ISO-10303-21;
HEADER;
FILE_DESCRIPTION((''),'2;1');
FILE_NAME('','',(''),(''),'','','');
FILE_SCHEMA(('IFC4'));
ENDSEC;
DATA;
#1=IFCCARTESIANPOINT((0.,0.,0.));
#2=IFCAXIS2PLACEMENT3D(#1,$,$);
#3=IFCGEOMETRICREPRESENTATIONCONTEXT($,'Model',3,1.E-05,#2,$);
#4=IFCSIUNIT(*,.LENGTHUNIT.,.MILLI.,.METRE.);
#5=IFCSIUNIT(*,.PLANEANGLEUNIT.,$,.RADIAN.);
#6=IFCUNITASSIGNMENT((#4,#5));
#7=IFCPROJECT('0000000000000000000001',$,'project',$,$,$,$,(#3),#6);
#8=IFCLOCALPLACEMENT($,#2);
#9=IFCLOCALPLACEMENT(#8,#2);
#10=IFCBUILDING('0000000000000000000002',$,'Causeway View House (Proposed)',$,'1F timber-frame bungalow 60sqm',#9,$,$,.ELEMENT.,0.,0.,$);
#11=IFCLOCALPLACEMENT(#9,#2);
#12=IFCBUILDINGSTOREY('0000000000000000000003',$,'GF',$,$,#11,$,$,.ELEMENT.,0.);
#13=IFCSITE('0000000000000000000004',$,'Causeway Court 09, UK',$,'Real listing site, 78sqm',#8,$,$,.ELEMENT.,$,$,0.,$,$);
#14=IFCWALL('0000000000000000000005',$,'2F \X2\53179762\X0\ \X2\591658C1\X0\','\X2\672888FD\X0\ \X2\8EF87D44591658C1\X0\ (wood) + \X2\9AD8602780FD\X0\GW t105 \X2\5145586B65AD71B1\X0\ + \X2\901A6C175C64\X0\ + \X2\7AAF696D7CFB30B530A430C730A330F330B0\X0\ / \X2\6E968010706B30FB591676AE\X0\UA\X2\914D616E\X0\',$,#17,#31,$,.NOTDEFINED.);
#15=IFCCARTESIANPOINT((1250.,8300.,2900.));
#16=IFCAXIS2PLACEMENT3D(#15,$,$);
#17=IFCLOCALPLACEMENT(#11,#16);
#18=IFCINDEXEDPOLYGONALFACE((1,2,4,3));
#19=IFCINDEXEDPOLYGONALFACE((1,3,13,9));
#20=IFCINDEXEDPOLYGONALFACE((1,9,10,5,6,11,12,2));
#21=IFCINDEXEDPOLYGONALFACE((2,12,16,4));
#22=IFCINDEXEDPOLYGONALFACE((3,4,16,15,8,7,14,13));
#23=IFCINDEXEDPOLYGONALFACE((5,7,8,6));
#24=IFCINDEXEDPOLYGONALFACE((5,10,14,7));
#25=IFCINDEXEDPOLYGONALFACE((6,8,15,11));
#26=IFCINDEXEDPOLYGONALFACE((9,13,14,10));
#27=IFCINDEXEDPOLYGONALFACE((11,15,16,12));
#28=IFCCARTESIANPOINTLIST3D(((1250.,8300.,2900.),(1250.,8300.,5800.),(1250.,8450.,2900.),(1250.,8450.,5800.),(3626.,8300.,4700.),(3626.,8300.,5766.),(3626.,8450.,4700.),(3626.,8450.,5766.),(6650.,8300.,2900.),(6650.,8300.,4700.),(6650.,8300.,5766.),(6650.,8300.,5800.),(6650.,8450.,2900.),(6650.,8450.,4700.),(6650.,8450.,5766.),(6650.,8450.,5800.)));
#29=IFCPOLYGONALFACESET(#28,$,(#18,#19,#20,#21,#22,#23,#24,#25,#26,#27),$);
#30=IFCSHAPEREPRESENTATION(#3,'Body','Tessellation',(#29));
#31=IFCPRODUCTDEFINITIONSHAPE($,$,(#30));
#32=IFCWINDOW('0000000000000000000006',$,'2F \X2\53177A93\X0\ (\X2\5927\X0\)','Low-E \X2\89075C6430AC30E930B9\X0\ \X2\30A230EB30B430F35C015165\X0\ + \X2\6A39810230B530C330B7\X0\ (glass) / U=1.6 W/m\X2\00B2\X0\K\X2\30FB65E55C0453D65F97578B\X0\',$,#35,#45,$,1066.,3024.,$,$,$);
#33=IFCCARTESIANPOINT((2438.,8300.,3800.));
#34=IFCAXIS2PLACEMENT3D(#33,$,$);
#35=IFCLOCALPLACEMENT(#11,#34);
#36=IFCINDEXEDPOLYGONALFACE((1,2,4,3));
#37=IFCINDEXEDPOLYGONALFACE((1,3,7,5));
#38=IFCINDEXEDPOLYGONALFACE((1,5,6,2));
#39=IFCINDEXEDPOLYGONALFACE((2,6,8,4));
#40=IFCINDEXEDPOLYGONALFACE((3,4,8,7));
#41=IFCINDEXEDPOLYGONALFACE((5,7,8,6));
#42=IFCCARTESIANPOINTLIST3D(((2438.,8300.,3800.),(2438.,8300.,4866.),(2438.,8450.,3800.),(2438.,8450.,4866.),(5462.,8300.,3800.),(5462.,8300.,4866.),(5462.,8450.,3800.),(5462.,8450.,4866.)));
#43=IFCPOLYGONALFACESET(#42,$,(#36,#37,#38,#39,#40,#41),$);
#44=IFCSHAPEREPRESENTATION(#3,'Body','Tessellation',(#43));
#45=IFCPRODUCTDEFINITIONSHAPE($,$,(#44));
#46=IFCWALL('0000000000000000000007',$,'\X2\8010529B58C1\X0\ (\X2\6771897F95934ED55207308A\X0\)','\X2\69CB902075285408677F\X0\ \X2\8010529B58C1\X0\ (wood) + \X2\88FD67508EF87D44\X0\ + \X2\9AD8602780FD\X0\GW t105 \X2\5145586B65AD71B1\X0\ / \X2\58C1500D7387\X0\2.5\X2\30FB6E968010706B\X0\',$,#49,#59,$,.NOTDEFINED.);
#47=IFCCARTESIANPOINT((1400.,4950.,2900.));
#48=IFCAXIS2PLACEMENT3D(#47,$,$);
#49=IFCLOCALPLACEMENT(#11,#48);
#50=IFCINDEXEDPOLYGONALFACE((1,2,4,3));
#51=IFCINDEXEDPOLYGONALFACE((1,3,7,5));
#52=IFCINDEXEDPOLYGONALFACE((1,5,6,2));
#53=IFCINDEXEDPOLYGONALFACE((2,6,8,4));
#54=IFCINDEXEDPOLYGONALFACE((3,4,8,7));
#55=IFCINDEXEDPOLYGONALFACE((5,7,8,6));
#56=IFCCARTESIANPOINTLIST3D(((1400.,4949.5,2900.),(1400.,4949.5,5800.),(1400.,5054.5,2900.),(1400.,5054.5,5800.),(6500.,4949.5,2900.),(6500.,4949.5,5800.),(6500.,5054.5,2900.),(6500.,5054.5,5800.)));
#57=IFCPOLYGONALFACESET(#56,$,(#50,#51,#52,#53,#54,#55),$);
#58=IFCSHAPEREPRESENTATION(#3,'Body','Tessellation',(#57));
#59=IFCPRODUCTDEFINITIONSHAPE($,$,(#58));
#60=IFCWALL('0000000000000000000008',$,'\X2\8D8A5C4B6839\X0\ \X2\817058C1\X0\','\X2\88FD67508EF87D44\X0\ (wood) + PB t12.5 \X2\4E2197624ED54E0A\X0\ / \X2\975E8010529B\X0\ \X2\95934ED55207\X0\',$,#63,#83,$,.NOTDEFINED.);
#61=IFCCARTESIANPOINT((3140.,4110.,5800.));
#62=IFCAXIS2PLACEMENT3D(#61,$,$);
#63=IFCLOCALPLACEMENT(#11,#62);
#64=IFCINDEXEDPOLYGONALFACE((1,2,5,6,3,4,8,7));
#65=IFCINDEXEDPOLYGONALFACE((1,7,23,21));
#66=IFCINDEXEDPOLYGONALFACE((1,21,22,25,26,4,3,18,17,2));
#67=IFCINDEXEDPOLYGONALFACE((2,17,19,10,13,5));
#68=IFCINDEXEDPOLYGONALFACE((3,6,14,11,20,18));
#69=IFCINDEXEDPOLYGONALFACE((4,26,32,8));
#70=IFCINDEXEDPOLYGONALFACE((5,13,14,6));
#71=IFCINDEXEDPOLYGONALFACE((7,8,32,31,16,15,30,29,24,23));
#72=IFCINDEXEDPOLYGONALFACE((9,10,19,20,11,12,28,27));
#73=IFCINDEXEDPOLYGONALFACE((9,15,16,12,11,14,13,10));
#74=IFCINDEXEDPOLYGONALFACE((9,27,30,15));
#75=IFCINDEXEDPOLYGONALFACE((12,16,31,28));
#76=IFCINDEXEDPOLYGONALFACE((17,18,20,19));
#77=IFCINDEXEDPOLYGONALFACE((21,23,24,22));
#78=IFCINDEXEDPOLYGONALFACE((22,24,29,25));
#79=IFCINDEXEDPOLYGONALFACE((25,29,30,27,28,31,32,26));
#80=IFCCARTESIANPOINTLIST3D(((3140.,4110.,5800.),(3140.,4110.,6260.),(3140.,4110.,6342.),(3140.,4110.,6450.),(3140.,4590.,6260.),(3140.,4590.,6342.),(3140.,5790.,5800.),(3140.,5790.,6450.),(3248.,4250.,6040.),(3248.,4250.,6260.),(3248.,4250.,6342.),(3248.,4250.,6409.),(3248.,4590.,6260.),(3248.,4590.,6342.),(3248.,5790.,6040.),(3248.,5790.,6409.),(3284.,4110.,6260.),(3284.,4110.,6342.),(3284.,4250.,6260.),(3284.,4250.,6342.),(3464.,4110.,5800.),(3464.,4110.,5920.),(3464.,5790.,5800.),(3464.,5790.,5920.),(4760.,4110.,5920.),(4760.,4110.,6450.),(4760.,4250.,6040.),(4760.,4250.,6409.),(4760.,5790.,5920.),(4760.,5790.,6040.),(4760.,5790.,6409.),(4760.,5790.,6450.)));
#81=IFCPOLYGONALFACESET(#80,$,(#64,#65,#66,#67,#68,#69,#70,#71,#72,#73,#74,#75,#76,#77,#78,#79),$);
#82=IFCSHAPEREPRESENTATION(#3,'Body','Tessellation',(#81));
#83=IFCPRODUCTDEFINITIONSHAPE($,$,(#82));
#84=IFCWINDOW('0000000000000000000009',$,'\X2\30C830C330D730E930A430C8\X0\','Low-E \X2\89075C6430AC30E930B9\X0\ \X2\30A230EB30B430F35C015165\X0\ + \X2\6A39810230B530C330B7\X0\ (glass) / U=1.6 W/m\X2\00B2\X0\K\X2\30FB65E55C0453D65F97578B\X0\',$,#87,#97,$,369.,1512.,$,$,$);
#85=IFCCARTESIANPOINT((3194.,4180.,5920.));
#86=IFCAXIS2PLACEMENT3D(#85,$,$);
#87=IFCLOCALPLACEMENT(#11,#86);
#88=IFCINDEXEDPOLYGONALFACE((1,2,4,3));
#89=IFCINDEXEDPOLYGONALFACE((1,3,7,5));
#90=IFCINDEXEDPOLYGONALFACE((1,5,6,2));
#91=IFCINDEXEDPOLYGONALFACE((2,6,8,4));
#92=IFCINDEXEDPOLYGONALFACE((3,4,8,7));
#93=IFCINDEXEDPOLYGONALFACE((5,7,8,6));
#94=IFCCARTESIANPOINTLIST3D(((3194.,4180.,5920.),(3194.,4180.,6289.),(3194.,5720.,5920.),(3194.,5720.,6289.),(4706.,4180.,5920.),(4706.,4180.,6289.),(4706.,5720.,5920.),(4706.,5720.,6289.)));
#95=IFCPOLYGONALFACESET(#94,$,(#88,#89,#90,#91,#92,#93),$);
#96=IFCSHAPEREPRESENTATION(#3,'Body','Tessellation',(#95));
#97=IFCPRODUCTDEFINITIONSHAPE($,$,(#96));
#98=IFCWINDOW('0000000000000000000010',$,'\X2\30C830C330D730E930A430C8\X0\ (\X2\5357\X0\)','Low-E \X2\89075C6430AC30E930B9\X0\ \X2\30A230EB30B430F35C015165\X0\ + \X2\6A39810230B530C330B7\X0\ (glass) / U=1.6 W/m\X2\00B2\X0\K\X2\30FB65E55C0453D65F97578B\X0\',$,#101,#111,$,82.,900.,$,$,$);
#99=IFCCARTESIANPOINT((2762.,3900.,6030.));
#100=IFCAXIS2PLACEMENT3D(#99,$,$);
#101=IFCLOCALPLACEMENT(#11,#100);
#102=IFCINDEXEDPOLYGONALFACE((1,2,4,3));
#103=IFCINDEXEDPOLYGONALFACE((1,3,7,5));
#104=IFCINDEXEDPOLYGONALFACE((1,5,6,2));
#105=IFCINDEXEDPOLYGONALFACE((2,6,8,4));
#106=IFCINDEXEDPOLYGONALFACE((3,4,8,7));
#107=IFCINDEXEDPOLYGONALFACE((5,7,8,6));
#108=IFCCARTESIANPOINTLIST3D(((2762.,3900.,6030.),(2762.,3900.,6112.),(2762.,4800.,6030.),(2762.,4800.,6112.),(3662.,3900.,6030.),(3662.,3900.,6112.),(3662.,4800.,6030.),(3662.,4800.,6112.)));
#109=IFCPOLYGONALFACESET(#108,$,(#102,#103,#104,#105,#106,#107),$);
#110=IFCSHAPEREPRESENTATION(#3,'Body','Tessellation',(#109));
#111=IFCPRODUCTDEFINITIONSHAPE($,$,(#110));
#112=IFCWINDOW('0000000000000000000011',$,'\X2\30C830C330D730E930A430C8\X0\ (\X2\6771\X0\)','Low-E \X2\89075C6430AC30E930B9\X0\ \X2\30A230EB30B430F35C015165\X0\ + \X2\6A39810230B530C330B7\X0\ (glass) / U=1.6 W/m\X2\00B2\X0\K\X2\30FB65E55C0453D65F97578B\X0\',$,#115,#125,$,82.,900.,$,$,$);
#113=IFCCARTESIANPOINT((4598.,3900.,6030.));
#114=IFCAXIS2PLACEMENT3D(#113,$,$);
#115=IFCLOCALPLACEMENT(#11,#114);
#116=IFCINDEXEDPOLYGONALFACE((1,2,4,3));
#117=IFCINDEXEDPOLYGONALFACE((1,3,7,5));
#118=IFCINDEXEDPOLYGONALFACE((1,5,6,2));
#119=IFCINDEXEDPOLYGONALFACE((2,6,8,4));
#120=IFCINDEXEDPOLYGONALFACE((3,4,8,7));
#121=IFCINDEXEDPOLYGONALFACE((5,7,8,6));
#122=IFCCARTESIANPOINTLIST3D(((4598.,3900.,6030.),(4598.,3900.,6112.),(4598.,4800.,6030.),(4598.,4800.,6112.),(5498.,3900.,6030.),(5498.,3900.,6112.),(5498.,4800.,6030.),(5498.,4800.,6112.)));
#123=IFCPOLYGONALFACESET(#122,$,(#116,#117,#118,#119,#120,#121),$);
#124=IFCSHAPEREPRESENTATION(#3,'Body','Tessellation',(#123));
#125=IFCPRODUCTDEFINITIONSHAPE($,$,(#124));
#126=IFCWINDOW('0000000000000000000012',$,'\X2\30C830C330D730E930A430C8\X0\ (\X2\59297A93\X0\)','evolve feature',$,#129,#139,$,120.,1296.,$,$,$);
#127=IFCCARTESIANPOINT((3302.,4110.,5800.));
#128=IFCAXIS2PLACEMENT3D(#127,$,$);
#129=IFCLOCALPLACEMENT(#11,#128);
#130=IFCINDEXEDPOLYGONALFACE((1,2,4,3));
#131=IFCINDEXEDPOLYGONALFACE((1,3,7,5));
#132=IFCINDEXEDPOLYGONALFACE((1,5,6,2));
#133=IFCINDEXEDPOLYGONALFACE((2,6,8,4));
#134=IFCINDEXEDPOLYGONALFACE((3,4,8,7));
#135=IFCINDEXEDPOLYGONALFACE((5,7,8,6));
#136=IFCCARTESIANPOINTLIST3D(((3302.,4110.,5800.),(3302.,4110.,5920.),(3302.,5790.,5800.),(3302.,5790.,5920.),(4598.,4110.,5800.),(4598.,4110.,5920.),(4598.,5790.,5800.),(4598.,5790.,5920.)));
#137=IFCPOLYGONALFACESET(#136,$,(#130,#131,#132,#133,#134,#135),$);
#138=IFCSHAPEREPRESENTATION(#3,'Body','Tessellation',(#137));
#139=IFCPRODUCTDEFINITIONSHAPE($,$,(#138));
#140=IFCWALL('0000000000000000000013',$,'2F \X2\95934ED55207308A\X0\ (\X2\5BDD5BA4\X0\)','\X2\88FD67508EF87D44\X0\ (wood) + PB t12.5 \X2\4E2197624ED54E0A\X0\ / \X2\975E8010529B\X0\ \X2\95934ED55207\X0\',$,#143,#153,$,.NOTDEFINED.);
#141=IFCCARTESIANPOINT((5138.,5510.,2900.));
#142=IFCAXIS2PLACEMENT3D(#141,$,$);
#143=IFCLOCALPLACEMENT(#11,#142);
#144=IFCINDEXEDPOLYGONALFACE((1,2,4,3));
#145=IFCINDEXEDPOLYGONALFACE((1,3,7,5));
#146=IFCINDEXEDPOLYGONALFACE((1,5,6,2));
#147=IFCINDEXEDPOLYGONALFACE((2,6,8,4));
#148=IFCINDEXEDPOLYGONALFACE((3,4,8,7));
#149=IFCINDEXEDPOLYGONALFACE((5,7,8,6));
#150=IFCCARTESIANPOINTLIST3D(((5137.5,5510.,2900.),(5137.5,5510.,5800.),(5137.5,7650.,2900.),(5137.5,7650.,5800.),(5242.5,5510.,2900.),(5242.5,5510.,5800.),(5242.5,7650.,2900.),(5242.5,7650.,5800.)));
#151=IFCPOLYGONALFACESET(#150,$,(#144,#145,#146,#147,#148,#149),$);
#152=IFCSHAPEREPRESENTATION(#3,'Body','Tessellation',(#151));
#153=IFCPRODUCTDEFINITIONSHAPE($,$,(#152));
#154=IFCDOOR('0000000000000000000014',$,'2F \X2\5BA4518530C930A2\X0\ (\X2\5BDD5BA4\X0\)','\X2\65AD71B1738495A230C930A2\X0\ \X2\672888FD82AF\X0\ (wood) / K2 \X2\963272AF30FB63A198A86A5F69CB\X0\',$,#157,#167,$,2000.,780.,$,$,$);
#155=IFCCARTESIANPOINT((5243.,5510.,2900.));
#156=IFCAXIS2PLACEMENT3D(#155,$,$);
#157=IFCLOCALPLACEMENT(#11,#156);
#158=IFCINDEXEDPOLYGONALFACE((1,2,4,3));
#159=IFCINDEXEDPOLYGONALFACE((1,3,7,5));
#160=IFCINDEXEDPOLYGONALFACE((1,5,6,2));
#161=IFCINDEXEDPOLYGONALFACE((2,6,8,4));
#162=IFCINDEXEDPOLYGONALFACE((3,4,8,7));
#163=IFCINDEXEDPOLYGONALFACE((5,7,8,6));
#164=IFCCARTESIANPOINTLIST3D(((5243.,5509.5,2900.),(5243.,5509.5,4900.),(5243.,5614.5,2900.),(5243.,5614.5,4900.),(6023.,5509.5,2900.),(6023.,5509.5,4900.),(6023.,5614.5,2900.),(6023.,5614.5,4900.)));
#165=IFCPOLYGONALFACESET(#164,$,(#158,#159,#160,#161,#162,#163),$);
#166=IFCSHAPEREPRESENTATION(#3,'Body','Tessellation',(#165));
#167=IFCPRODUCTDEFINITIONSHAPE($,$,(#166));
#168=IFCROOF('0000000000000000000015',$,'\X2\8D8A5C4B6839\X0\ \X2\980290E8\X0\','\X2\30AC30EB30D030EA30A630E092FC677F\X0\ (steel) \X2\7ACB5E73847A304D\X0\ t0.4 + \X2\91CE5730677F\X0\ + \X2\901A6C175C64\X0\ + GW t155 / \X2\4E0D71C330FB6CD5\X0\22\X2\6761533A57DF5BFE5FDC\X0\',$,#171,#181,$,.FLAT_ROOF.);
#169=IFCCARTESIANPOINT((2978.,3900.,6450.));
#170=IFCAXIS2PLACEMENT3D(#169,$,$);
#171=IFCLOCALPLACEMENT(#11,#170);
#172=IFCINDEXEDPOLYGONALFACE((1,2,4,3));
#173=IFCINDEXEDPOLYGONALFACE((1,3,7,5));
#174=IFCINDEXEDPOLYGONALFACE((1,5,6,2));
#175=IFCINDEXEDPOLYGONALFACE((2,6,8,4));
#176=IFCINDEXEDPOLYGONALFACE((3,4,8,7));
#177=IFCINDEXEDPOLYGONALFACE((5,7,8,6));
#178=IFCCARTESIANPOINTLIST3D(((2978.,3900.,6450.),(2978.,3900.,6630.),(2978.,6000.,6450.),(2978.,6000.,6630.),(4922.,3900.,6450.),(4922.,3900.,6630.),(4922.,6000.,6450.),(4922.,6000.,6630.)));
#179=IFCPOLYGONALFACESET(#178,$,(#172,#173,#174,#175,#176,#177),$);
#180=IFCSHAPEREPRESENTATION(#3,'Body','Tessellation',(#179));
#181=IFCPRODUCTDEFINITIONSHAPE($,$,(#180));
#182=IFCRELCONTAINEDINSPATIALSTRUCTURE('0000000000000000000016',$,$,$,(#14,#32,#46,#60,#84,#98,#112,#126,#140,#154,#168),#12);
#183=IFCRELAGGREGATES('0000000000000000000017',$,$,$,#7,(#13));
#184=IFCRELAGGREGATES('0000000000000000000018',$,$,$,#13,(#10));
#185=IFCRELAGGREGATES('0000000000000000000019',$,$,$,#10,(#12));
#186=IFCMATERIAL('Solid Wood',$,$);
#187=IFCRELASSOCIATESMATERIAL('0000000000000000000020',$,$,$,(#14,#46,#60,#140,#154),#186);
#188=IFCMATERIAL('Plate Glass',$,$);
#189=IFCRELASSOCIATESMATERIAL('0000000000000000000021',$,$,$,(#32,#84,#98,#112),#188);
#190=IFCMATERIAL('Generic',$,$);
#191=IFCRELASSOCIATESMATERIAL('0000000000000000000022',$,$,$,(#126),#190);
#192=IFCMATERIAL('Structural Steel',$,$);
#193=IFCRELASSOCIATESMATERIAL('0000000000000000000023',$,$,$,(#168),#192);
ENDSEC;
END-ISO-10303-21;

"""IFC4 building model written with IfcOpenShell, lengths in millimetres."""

from ifc_helpers import new_model, si_unit, frame, frame_2d, origin, place, context, project, spatial, rectangle, extrude, material, element, fill, save


model = new_model("IFC4")

# Units and contexts
model_context = context("Model", 3, precision=1e-05, world=origin())
ifc_project = project(units=[si_unit("LENGTHUNIT", "METRE", prefix="MILLI"), si_unit("PLANEANGLEUNIT", "RADIAN")], contexts=[model_context])

# Site, building, storey
site_placement = place(None, origin())
site = spatial("IfcSite", under=ifc_project, at=site_placement, Name="Causeway Court 09, UK", ObjectType="Real listing site, 78sqm", CompositionType="ELEMENT", RefElevation=0.0)
building_placement = place(site_placement, origin())
building = spatial("IfcBuilding", under=site, at=building_placement, Name="Causeway View House (Proposed)", ObjectType="1F timber-frame bungalow 60sqm", CompositionType="ELEMENT", ElevationOfRefHeight=0.0, ElevationOfTerrain=0.0)
storey_placement = place(building_placement, origin())
storey = spatial("IfcBuildingStorey", under=building, at=storey_placement, Name="GF", CompositionType="ELEMENT", Elevation=0.0)

# Wall, opening, window
ifc_material_1 = material(Name="Solid Wood")
wall_1_placement = place(storey_placement, frame((1250.0, 8300.0, 2900.0)))
wall_1 = element("IfcWall", 1, at=wall_1_placement, inside=storey, material=ifc_material_1, Name="2F 北面 外壁", Description="木製 軸組外壁 (wood) + 高性能GW t105 充填断熱 + 通気層 + 窯業系サイディング / 準耐火・外皮UA配慮", PredefinedType="NOTDEFINED", context=model_context, shape_type="SweptSolid", body=[
    extrude(rectangle(XDim=5400.0, YDim=150.0, at=frame_2d((2700.0, 75.0))), frame((1250.0, 8300.0, 2900.0)), (0.0, 0.0, 1.0), 2900.0),
])
opening_1_placement = place(storey_placement, frame((2438.0, 8300.0, 3800.0)))
opening_1 = element("IfcOpeningElement", 2, at=opening_1_placement, cuts=wall_1, PredefinedType="NOTDEFINED", context=model_context, shape_type="SweptSolid", body=[
    extrude(rectangle(XDim=3024.0, YDim=150.0, at=frame_2d((1512.0, 75.0))), frame((2438.0, 8300.0, 3800.0)), (0.0, 0.0, 1.0), 1066.0),
])
ifc_material_2 = material(Name="Plate Glass")
window_1_placement = place(storey_placement, frame((2438.0, 8300.0, 3800.0)))
window_1 = element("IfcWindow", 3, at=window_1_placement, inside=storey, material=ifc_material_2, Name="2F 北窓 (大)", Description="Low-E 複層ガラス アルゴン封入 + 樹脂サッシ (glass) / U=1.6 W/m²K・日射取得型", OverallHeight=1066.0, OverallWidth=3024.0, context=model_context, shape_type="SweptSolid", body=[
    extrude(rectangle(XDim=3024.0, YDim=150.0, at=frame_2d((1512.0, 75.0))), frame((2438.0, 8300.0, 3800.0)), (0.0, 0.0, 1.0), 1066.0),
])
fill(opening_1, window_1)

# Wall
wall_2_placement = place(storey_placement, frame((1400.0, 4950.0, 2900.0)))
element("IfcWall", 4, at=wall_2_placement, inside=storey, material=ifc_material_1, Name="耐力壁 (東西間仕切り)", Description="構造用合板 耐力壁 (wood) + 製材軸組 + 高性能GW t105 充填断熱 / 壁倍率2.5・準耐火", PredefinedType="NOTDEFINED", context=model_context, shape_type="SweptSolid", body=[
    extrude(rectangle(XDim=5100.0, YDim=105.0, at=frame_2d((2550.0, 52.0))), frame((1400.0, 4950.0, 2900.0)), (0.0, 0.0, 1.0), 2900.0),
])

# Wall, openings, windows
wall_3_placement = place(storey_placement, frame((3140.0, 4110.0, 5800.0)))
wall_3 = element("IfcWall", 5, at=wall_3_placement, inside=storey, material=ifc_material_1, Name="越屋根 腰壁", Description="製材軸組 (wood) + PB t12.5 両面仕上 / 非耐力 間仕切", PredefinedType="NOTDEFINED", context=model_context, shape_type="SweptSolid", body=[
    extrude(rectangle(XDim=1620.0, YDim=1680.0, at=frame_2d((810.0, 840.0))), frame((3140.0, 4110.0, 5800.0)), (0.0, 0.0, 1.0), 650.0),
])
opening_2_placement = place(storey_placement, frame((3194.0, 4180.0, 5920.0)))
opening_2 = element("IfcOpeningElement", 6, at=opening_2_placement, cuts=wall_3, PredefinedType="NOTDEFINED", context=model_context, shape_type="SweptSolid", body=[
    extrude(rectangle(XDim=1512.0, YDim=1540.0, at=frame_2d((756.0, 770.0))), frame((3194.0, 4180.0, 5920.0)), (0.0, 0.0, 1.0), 369.0),
])
opening_3_placement = place(storey_placement, frame((2762.0, 3900.0, 6030.0)))
opening_3 = element("IfcOpeningElement", 7, at=opening_3_placement, cuts=wall_3, PredefinedType="NOTDEFINED", context=model_context, shape_type="SweptSolid", body=[
    extrude(rectangle(XDim=900.0, YDim=900.0, at=frame_2d((450.0, 450.0))), frame((2762.0, 3900.0, 6030.0)), (0.0, 0.0, 1.0), 82.0),
])
opening_4_placement = place(storey_placement, frame((4598.0, 3900.0, 6030.0)))
opening_4 = element("IfcOpeningElement", 8, at=opening_4_placement, cuts=wall_3, PredefinedType="NOTDEFINED", context=model_context, shape_type="SweptSolid", body=[
    extrude(rectangle(XDim=900.0, YDim=900.0, at=frame_2d((450.0, 450.0))), frame((4598.0, 3900.0, 6030.0)), (0.0, 0.0, 1.0), 82.0),
])
opening_5_placement = place(storey_placement, frame((3302.0, 4110.0, 5800.0)))
opening_5 = element("IfcOpeningElement", 9, at=opening_5_placement, cuts=wall_3, PredefinedType="NOTDEFINED", context=model_context, shape_type="SweptSolid", body=[
    extrude(rectangle(XDim=1296.0, YDim=1680.0, at=frame_2d((648.0, 840.0))), frame((3302.0, 4110.0, 5800.0)), (0.0, 0.0, 1.0), 120.0),
])
window_2_placement = place(storey_placement, frame((3194.0, 4180.0, 5920.0)))
window_2 = element("IfcWindow", 10, at=window_2_placement, inside=storey, material=ifc_material_2, Name="トップライト", Description="Low-E 複層ガラス アルゴン封入 + 樹脂サッシ (glass) / U=1.6 W/m²K・日射取得型", OverallHeight=369.0, OverallWidth=1512.0, context=model_context, shape_type="SweptSolid", body=[
    extrude(rectangle(XDim=1512.0, YDim=1540.0, at=frame_2d((756.0, 770.0))), frame((3194.0, 4180.0, 5920.0)), (0.0, 0.0, 1.0), 369.0),
])
fill(opening_2, window_2)
window_3_placement = place(storey_placement, frame((2762.0, 3900.0, 6030.0)))
window_3 = element("IfcWindow", 11, at=window_3_placement, inside=storey, material=ifc_material_2, Name="トップライト (南)", Description="Low-E 複層ガラス アルゴン封入 + 樹脂サッシ (glass) / U=1.6 W/m²K・日射取得型", OverallHeight=82.0, OverallWidth=900.0, context=model_context, shape_type="SweptSolid", body=[
    extrude(rectangle(XDim=900.0, YDim=900.0, at=frame_2d((450.0, 450.0))), frame((2762.0, 3900.0, 6030.0)), (0.0, 0.0, 1.0), 82.0),
])
fill(opening_3, window_3)
window_4_placement = place(storey_placement, frame((4598.0, 3900.0, 6030.0)))
window_4 = element("IfcWindow", 12, at=window_4_placement, inside=storey, material=ifc_material_2, Name="トップライト (東)", Description="Low-E 複層ガラス アルゴン封入 + 樹脂サッシ (glass) / U=1.6 W/m²K・日射取得型", OverallHeight=82.0, OverallWidth=900.0, context=model_context, shape_type="SweptSolid", body=[
    extrude(rectangle(XDim=900.0, YDim=900.0, at=frame_2d((450.0, 450.0))), frame((4598.0, 3900.0, 6030.0)), (0.0, 0.0, 1.0), 82.0),
])
fill(opening_4, window_4)
ifc_material_3 = material(Name="Generic")
window_5_placement = place(storey_placement, frame((3302.0, 4110.0, 5800.0)))
window_5 = element("IfcWindow", 13, at=window_5_placement, inside=storey, material=ifc_material_3, Name="トップライト (天窓)", Description="evolve feature", OverallHeight=120.0, OverallWidth=1296.0, context=model_context, shape_type="SweptSolid", body=[
    extrude(rectangle(XDim=1296.0, YDim=1680.0, at=frame_2d((648.0, 840.0))), frame((3302.0, 4110.0, 5800.0)), (0.0, 0.0, 1.0), 120.0),
])
fill(opening_5, window_5)

# Wall
wall_4_placement = place(storey_placement, frame((5138.0, 5510.0, 2900.0)))
element("IfcWall", 14, at=wall_4_placement, inside=storey, material=ifc_material_1, Name="2F 間仕切り (寝室)", Description="製材軸組 (wood) + PB t12.5 両面仕上 / 非耐力 間仕切", PredefinedType="NOTDEFINED", context=model_context, shape_type="SweptSolid", body=[
    extrude(rectangle(XDim=105.0, YDim=2140.0, at=frame_2d((52.0, 1070.0))), frame((5138.0, 5510.0, 2900.0)), (0.0, 0.0, 1.0), 2900.0),
])

# Door
door_placement = place(storey_placement, frame((5243.0, 5510.0, 2900.0)))
element("IfcDoor", 15, at=door_placement, inside=storey, material=ifc_material_1, Name="2F 室内ドア (寝室)", Description="断熱玄関ドア 木製芯 (wood) / K2 防犯・採風機構", OverallHeight=2000.0, OverallWidth=780.0, context=model_context, shape_type="SweptSolid", body=[
    extrude(rectangle(XDim=780.0, YDim=105.0, at=frame_2d((390.0, 52.0))), frame((5243.0, 5510.0, 2900.0)), (0.0, 0.0, 1.0), 2000.0),
])

# Roof
ifc_material_4 = material(Name="Structural Steel")
roof_placement = place(storey_placement, frame((2978.0, 3900.0, 6450.0)))
element("IfcRoof", 16, at=roof_placement, inside=storey, material=ifc_material_4, Name="越屋根 頂部", Description="ガルバリウム鋼板 (steel) 立平葺き t0.4 + 野地板 + 通気層 + GW t155 / 不燃・法22条区域対応", PredefinedType="FLAT_ROOF", context=model_context, shape_type="SweptSolid", body=[
    extrude(rectangle(XDim=1944.0, YDim=2100.0, at=frame_2d((972.0, 1050.0))), frame((2978.0, 3900.0, 6450.0)), (0.0, 0.0, 1.0), 180.0),
])

save(model, "model.ifc")
